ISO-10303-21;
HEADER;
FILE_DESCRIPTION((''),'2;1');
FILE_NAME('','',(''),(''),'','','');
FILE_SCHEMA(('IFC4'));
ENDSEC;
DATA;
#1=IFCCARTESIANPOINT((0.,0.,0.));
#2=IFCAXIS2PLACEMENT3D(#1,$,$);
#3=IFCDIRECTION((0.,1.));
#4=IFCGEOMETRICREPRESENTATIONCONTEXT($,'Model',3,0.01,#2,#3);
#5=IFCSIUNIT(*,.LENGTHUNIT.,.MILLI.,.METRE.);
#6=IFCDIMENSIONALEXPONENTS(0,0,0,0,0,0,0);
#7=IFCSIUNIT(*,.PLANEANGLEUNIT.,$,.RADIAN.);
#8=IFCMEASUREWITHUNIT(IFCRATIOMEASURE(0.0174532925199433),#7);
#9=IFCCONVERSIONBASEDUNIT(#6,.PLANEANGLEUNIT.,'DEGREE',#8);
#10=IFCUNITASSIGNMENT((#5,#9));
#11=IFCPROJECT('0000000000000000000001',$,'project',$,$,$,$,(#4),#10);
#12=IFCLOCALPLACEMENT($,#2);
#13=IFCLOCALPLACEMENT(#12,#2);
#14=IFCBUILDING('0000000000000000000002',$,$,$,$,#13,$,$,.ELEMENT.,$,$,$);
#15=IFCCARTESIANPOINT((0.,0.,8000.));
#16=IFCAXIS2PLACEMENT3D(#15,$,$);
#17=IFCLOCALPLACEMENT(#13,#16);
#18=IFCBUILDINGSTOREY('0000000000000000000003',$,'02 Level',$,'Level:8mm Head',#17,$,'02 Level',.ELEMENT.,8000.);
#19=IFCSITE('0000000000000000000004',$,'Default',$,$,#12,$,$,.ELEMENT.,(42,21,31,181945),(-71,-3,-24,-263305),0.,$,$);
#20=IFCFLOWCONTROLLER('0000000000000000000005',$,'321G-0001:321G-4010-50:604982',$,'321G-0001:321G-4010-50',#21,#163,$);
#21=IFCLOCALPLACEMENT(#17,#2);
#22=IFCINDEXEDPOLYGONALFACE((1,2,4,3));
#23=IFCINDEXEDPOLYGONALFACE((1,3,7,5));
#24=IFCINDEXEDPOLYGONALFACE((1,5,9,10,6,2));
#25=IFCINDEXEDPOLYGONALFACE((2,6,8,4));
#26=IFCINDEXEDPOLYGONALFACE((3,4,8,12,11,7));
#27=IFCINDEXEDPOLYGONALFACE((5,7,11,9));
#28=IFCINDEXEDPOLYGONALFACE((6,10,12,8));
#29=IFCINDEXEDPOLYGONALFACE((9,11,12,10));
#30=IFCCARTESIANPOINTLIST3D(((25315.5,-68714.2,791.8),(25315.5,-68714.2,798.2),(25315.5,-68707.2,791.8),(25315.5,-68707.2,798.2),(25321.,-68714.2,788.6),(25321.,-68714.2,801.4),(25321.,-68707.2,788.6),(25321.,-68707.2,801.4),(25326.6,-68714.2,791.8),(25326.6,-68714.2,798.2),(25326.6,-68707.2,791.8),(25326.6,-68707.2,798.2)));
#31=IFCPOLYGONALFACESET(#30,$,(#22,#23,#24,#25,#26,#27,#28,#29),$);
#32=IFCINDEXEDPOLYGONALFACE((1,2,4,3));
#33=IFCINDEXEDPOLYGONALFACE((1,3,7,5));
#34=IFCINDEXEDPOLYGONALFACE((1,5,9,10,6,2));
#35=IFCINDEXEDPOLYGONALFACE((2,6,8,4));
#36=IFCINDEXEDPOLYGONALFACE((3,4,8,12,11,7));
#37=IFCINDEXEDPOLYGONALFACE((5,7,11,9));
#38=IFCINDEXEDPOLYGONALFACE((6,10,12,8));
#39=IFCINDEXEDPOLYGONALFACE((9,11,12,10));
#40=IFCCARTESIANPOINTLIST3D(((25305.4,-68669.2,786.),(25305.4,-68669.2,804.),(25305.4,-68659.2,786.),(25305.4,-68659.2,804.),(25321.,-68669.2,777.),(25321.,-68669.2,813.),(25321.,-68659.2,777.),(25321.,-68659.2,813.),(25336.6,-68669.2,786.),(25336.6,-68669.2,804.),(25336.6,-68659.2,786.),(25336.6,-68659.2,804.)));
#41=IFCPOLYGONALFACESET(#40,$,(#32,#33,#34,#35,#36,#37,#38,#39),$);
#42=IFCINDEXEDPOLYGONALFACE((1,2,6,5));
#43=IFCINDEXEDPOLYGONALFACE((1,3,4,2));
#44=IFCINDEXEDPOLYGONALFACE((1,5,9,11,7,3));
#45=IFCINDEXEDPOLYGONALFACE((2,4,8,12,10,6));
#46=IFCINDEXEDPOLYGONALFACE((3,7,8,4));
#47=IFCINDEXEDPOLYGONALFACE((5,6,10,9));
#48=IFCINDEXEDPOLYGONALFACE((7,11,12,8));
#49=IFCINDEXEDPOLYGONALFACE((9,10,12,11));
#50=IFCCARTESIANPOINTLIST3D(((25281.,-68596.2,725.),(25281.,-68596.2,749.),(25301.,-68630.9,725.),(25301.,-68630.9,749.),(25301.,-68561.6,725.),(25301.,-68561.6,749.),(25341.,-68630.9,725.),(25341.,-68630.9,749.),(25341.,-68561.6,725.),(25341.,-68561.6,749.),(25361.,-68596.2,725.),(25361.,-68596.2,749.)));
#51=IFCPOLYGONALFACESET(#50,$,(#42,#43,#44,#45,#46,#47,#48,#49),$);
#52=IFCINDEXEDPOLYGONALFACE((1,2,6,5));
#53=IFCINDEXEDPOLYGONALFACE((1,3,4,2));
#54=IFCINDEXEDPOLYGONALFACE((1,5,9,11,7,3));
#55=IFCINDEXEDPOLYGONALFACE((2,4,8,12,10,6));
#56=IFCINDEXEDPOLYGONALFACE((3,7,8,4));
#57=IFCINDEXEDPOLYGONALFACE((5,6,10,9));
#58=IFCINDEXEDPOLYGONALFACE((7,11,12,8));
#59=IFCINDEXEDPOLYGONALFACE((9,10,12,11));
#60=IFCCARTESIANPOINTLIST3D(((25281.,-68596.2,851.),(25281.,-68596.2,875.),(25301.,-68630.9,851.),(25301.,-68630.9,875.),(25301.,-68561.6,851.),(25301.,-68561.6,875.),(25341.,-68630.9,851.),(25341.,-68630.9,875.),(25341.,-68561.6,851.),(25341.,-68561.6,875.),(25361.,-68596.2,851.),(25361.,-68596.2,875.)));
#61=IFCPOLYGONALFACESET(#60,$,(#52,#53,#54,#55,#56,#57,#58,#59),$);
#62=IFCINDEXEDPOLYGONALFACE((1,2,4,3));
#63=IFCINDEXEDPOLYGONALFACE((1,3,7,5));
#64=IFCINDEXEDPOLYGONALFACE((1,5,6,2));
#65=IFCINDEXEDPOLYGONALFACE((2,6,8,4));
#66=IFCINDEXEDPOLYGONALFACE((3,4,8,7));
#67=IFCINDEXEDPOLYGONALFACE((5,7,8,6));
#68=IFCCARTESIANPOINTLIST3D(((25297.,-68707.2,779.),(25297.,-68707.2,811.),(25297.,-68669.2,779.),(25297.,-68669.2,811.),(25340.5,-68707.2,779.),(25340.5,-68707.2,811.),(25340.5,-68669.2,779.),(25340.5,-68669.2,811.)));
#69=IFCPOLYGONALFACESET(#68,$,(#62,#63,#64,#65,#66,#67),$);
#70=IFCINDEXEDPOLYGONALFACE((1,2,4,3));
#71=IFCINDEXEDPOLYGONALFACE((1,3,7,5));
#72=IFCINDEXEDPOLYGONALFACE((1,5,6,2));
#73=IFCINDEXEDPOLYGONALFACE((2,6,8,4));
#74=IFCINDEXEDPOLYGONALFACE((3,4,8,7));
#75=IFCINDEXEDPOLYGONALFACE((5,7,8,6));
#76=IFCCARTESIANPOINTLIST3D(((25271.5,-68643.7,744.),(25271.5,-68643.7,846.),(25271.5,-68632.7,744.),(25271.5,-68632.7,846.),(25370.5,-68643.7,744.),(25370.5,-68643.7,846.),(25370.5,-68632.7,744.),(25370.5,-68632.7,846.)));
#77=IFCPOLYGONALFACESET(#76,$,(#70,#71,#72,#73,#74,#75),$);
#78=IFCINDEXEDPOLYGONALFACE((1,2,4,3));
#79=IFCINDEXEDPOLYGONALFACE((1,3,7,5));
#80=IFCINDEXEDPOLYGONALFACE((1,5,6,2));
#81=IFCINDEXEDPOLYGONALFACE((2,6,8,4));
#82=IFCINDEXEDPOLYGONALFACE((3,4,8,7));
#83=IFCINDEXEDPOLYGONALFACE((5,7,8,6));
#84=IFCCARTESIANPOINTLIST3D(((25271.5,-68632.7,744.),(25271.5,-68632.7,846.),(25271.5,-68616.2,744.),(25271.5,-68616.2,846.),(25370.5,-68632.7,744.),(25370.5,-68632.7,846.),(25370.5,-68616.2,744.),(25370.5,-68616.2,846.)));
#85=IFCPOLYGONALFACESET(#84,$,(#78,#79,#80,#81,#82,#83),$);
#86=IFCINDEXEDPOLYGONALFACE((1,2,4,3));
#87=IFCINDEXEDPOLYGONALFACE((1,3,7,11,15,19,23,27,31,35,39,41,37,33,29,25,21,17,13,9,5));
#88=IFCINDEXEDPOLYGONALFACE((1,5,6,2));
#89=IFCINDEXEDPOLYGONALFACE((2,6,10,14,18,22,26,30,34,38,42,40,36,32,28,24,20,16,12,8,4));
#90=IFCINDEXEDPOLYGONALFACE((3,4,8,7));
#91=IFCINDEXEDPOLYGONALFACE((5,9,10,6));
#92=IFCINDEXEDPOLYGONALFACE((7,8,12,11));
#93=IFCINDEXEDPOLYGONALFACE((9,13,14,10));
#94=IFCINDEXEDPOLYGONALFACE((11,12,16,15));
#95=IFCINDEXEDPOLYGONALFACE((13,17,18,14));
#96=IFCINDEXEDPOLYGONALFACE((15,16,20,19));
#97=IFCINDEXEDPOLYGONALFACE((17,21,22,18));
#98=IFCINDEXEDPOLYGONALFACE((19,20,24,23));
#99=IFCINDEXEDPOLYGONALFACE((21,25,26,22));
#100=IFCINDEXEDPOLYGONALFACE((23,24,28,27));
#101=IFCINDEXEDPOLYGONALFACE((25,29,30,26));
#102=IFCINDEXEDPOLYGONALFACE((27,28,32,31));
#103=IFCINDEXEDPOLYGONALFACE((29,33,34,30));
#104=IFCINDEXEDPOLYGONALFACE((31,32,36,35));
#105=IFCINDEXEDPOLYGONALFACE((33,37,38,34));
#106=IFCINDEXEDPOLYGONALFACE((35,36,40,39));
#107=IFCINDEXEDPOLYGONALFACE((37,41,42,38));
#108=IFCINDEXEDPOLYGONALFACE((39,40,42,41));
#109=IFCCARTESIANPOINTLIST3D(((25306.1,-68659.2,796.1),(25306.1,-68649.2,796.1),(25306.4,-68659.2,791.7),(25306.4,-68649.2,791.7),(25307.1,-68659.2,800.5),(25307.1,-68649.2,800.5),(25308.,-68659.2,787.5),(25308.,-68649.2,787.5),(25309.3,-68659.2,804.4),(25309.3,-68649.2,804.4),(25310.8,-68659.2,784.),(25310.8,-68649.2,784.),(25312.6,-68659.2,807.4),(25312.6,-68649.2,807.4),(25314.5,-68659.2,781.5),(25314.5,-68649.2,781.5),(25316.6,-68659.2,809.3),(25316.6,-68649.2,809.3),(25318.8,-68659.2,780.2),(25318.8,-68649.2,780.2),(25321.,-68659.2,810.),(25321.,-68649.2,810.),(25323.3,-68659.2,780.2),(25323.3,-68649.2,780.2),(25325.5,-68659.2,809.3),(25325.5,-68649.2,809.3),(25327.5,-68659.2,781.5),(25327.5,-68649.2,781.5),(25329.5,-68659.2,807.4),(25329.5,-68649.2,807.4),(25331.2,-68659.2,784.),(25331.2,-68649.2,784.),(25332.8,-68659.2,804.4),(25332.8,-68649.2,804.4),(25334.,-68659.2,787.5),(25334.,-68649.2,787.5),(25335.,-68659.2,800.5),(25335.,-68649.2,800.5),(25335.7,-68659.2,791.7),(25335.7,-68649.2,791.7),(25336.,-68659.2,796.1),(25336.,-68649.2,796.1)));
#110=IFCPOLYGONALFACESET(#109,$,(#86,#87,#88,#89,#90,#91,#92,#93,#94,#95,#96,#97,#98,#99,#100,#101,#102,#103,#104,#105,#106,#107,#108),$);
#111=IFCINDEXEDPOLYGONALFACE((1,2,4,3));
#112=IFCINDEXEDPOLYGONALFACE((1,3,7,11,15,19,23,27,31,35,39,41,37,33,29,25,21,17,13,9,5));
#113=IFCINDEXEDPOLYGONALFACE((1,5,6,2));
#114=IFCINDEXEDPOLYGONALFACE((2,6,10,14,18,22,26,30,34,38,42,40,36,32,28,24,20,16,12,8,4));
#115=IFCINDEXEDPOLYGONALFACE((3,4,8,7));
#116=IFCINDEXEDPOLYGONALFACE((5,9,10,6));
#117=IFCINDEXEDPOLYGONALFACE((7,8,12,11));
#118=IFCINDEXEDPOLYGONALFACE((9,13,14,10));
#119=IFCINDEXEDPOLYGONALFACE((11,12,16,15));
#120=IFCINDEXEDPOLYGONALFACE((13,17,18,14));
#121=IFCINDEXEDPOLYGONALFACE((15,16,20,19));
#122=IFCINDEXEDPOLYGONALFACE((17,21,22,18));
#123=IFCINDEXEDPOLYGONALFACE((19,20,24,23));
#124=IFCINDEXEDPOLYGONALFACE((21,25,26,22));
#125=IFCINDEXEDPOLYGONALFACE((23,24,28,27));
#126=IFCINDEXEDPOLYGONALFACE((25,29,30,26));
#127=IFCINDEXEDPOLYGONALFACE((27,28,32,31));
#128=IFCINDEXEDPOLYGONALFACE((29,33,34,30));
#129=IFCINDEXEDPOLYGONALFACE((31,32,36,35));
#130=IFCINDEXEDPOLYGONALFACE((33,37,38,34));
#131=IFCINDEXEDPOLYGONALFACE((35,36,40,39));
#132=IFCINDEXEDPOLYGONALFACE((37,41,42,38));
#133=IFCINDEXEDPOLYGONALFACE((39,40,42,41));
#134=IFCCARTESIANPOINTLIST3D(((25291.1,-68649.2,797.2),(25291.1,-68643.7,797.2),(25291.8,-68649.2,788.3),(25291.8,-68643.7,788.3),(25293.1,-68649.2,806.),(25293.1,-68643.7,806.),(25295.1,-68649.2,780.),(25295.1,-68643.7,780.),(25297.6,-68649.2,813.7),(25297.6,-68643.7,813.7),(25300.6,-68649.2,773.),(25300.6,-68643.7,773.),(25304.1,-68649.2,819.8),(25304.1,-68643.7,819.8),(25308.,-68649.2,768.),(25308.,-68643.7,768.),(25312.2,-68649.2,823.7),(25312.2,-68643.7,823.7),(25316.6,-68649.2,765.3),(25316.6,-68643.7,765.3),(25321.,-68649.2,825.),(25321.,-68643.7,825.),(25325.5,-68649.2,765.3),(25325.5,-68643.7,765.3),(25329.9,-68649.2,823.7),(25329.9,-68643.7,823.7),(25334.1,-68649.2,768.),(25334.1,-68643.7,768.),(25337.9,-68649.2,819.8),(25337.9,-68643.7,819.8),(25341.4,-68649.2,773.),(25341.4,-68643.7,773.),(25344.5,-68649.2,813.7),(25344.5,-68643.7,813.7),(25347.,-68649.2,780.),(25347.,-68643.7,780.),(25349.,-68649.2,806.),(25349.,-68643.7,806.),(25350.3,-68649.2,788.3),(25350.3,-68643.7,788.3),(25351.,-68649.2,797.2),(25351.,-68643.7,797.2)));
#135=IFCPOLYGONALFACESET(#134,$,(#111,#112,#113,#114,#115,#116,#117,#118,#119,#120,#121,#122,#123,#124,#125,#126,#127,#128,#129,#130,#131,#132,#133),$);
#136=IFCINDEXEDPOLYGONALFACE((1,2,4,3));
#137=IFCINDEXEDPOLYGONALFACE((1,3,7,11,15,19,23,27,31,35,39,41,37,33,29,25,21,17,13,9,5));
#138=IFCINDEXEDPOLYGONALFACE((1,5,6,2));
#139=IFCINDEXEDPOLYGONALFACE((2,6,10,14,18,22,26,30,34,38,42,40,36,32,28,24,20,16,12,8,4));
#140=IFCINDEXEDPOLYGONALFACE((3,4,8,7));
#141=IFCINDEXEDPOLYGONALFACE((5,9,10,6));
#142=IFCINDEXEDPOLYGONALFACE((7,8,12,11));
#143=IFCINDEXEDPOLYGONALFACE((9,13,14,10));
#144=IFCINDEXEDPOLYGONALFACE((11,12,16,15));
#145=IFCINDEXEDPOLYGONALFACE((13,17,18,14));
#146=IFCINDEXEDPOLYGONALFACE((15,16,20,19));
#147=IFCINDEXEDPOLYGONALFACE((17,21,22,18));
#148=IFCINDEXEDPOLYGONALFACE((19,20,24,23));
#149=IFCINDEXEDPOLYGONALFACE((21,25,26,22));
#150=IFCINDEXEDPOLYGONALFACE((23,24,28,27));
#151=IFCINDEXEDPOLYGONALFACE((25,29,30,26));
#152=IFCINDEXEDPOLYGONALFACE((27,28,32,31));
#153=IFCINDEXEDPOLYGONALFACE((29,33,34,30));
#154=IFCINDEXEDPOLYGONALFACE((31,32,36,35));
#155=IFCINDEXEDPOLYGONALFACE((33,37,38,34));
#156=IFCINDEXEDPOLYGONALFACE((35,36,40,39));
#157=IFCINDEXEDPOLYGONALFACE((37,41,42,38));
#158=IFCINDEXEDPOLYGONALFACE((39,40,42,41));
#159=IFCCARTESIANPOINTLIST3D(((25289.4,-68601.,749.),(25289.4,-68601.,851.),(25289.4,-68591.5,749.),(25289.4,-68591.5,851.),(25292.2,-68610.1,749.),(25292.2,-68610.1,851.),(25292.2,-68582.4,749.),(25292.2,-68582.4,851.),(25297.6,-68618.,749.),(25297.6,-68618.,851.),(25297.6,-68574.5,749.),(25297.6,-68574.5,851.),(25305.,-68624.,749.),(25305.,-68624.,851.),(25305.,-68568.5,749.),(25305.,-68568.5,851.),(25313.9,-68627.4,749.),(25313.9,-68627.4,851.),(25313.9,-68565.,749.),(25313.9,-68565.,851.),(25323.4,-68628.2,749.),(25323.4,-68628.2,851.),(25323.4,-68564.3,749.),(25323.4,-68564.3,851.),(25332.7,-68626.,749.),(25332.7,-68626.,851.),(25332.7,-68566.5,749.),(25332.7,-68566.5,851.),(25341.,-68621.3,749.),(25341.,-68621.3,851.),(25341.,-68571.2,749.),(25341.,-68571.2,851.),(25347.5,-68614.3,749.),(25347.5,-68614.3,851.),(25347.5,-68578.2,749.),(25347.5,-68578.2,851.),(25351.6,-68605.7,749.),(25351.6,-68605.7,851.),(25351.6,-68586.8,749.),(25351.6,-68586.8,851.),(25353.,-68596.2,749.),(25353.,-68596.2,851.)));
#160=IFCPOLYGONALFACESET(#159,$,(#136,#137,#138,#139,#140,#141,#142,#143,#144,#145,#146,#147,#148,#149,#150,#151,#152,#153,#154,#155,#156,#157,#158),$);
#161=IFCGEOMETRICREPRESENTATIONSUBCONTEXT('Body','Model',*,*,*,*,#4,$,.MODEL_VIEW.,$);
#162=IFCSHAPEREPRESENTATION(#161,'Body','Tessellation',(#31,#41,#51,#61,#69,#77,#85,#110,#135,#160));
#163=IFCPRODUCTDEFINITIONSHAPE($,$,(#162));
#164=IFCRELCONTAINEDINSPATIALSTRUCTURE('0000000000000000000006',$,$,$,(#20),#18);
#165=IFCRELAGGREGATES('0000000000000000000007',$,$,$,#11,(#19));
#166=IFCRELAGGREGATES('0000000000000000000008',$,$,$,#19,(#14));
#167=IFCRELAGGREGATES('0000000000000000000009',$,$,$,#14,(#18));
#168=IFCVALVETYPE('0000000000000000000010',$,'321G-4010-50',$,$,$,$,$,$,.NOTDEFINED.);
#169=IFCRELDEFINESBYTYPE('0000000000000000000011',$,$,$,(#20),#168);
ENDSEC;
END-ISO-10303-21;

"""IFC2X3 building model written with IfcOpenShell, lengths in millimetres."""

from ifc_helpers import new_model, entity, si_unit, converted_unit, direction, frame, frame_2d, origin, origin_2d_with_axis, place, context, subcontext, project, spatial, polyline, rectangle, circle, outline, extrude, source, transform, mapped, type_object, type_shapes, element, save


model = new_model("IFC2X3")

# Units and contexts
model_context = context("Model", 3, precision=0.01, world=origin(), true_north=direction((0.0, 1.0)))
body_context = subcontext(model_context, "Body", "Model", "MODEL_VIEW")
ifc_project = project(units=[si_unit("LENGTHUNIT", "METRE", prefix="MILLI"), converted_unit("PLANEANGLEUNIT", "DEGREE", entity("IfcRatioMeasure", 0.0174532925199433), si_unit("PLANEANGLEUNIT", "RADIAN"), dimensions=[0, 0, 0, 0, 0, 0, 0])], contexts=[model_context])

# Site, building, storey
site_placement = place(None, origin())
site = spatial("IfcSite", under=ifc_project, at=site_placement, Name="Default", CompositionType="ELEMENT", RefLatitude=(42, 21, 31, 181945), RefLongitude=(-71, -3, -24, -263305), RefElevation=0.0)
building_placement = place(site_placement, origin())
building = spatial("IfcBuilding", under=site, at=building_placement, CompositionType="ELEMENT")
storey_placement = place(building_placement, frame((0.0, 0.0, 8000.0)))
storey = spatial("IfcBuildingStorey", under=building, at=storey_placement, Name="02 Level", ObjectType="Level:8mm Head", LongName="02 Level", CompositionType="ELEMENT", Elevation=8000.0)

# Flow controller
valve_type_1 = type_object("IfcValveType", Name="321G-4010-50", PredefinedType="NOTDEFINED")
shared_shape_1 = source(origin(), body_context, "Body", "SweptSolid", [
    extrude(outline(polyline([(-3.2, -5.5), (3.2, -5.5), (6.4, 0.0), (3.2, 5.5), (-3.2, 5.5), (-6.4, 0.0), (-3.2, -5.5)])), frame((-5.0, 0.0, 111.0), z_axis=(0.0, 0.0, 1.0), x_axis=(0.5, 0.866025, 0.0)), (0.0, 0.0, 1.0), 7.0),
    extrude(outline(polyline([(-9.0, -15.6), (9.0, -15.6), (18.0, 0.0), (9.0, 15.6), (-9.0, 15.6), (-18.0, 0.0), (-9.0, -15.6)])), frame((-5.0, 0.0, 63.0), z_axis=(0.0, 0.0, 1.0), x_axis=(0.5, 0.866025, 0.0)), (0.0, 0.0, 1.0), 10.0),
    extrude(outline(polyline([(-20.0, -34.6), (20.0, -34.6), (40.0, 0.0), (20.0, 34.6), (-20.0, 34.6), (-40.0, 0.0), (-20.0, -34.6)])), frame((-75.0, 0.0, 0.0), z_axis=(1.0, 0.0, 0.0), x_axis=(0.0, -0.5, -0.866025)), (0.0, 0.0, 1.0), 24.0),
    extrude(outline(polyline([(-20.0, -34.6), (20.0, -34.6), (40.0, 0.0), (20.0, 34.6), (-20.0, 34.6), (-40.0, 0.0), (-20.0, -34.6)])), frame((51.0, 0.0, 0.0), z_axis=(1.0, 0.0, 0.0), x_axis=(0.0, -0.5, -0.866025)), (0.0, 0.0, 1.0), 24.0),
    extrude(rectangle(XDim=43.5, YDim=32.0, at=frame_2d((0.0, 0.0), x_axis=(1.0, 0.0))), frame((-5.0, 2.2, 73.0), z_axis=(0.0, 0.0, 1.0), x_axis=(0.0, -1.0, 0.0)), (0.0, 0.0, 1.0), 38.0),
    extrude(rectangle(XDim=99.0, YDim=102.0, at=origin_2d_with_axis()), frame((-5.0, 0.0, 36.5), z_axis=(0.0, 0.0, 1.0), x_axis=(0.0, -1.0, 0.0)), (0.0, 0.0, 1.0), 11.0),
    extrude(rectangle(XDim=99.0, YDim=102.0, at=origin_2d_with_axis()), frame((-5.0, 0.0, 20.0), z_axis=(0.0, 0.0, 1.0), x_axis=(0.0, -1.0, 0.0)), (0.0, 0.0, 1.0), 16.5),
    extrude(circle(Radius=15.0, at=frame_2d((0.0, 0.0), x_axis=(1.0, 0.0))), frame((-5.0, 0.0, 53.0)), (0.0, 0.0, 1.0), 10.0),
    extrude(circle(Radius=30.0, at=frame_2d((0.0, 0.0), x_axis=(1.0, 0.0))), frame((-5.0, 0.0, 47.5)), (0.0, 0.0, 1.0), 5.5),
    extrude(circle(Radius=32.0, at=frame_2d((0.0, 0.0), x_axis=(1.0, 0.0))), frame((-51.0, 0.0, 0.0), z_axis=(1.0, 0.0, 0.0), x_axis=(0.0, -1.0, 0.0)), (0.0, 0.0, 1.0), 102.0),
])
type_shapes(valve_type_1, [shared_shape_1])
flow_controller_1_placement = place(storey_placement, frame((25321.0, -68596.2, 800.0), z_axis=(0.0, -1.0, 0.0), x_axis=(0.0, 0.0, 1.0)))
element("IfcFlowController", 1, at=flow_controller_1_placement, inside=storey, type_object=valve_type_1, Name="321G-0001:321G-4010-50:604982", ObjectType="321G-0001:321G-4010-50", context=body_context, shape_type="MappedRepresentation", body=[
    mapped(shared_shape_1, transform((0.0, 0.0, 0.0), scale=1.0)),
])

save(model, "model.ifc")
